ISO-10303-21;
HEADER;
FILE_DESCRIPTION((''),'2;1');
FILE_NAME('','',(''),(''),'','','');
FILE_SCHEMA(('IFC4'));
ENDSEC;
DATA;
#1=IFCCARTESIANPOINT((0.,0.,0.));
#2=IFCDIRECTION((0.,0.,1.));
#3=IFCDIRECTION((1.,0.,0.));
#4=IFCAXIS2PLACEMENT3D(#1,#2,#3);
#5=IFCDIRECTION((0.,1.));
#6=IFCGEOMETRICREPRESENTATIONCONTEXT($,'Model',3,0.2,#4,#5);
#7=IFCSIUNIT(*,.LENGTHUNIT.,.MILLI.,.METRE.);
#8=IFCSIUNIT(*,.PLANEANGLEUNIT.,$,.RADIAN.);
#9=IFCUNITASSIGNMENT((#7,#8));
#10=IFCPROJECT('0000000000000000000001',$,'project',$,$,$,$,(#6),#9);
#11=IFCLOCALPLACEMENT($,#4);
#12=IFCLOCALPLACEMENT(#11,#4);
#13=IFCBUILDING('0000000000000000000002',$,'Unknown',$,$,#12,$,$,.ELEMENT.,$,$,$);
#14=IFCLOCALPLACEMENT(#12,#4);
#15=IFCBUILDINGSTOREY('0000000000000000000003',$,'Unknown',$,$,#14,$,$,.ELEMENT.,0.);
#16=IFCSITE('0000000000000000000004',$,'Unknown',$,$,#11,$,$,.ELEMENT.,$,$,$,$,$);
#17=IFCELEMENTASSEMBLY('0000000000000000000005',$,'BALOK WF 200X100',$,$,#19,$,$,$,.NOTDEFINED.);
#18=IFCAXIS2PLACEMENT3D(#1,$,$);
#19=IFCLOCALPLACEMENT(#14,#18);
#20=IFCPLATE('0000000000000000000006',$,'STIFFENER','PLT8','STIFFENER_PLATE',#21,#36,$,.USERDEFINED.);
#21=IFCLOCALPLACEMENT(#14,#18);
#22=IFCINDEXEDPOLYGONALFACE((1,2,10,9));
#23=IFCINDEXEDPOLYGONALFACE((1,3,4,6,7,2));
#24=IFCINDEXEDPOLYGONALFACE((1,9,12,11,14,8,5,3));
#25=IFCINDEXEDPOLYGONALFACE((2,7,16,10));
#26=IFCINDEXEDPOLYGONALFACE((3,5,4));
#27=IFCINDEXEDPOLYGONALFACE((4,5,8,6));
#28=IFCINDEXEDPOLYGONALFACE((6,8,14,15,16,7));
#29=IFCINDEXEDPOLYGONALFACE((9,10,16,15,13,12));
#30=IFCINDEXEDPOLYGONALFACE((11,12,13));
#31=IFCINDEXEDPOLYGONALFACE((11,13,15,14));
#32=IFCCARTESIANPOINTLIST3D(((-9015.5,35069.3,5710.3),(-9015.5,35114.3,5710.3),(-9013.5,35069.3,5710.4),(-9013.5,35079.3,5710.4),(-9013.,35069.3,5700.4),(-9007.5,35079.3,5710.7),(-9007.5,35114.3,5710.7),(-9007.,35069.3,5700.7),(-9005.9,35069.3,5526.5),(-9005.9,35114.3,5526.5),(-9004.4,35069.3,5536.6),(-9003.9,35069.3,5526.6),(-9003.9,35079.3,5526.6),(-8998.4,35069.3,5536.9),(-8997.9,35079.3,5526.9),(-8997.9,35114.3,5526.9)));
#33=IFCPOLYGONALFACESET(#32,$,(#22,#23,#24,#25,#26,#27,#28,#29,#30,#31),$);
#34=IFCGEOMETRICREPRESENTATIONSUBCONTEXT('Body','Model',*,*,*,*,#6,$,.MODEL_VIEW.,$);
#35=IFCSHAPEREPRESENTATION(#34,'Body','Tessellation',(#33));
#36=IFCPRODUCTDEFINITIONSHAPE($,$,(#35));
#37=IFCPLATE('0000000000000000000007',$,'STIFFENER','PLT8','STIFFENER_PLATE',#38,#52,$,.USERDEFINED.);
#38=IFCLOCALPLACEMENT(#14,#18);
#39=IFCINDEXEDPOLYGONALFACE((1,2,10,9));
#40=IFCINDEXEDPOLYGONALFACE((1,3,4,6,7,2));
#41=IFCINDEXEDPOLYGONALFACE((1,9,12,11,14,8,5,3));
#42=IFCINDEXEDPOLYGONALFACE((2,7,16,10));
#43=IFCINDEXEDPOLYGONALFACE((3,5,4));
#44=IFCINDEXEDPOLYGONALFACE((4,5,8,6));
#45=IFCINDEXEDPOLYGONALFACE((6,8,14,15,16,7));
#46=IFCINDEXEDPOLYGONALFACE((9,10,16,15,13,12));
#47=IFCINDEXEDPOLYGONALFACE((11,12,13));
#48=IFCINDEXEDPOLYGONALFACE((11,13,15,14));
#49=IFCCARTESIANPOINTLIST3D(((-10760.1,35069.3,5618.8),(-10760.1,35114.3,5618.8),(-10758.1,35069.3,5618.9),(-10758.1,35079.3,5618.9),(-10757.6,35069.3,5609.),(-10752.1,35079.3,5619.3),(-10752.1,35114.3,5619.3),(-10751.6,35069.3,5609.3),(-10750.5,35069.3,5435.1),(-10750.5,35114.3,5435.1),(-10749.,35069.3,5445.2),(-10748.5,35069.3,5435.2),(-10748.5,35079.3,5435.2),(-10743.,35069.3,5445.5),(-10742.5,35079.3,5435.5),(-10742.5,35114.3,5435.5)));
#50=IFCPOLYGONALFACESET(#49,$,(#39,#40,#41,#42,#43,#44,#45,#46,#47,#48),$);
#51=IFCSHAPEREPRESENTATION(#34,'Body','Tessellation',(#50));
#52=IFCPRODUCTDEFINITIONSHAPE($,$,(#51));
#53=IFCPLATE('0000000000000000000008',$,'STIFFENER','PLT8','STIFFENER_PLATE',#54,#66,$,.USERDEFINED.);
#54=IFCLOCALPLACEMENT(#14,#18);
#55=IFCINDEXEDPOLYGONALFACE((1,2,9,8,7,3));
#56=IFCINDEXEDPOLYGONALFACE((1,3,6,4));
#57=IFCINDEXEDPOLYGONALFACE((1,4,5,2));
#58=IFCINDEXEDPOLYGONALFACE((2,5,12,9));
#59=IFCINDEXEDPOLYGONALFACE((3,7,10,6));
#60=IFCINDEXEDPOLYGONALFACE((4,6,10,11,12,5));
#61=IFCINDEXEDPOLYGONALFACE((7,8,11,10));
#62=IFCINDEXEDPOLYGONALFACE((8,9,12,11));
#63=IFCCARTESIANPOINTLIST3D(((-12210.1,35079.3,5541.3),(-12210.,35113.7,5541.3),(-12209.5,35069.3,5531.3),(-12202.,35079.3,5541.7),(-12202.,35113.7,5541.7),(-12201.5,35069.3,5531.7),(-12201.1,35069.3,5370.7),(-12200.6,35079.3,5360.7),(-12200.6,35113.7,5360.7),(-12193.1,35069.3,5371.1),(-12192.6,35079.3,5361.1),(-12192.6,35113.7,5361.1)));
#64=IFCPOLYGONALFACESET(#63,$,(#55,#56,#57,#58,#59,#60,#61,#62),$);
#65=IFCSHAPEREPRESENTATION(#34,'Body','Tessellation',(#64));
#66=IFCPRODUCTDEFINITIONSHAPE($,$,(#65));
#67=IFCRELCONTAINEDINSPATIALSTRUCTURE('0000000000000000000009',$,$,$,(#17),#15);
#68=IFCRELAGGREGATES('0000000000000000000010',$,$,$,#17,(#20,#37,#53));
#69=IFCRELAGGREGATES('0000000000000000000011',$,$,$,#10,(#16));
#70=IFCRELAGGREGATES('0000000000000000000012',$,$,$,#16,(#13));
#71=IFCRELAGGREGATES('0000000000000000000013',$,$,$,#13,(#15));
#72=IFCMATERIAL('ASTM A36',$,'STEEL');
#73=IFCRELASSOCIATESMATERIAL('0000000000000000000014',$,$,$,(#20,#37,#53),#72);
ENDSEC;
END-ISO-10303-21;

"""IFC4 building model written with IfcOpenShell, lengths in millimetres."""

from ifc_helpers import new_model, si_unit, direction, frame, origin_with_axes, place, context, subcontext, project, spatial, line, indexed_curve, outline, extrude, material, element, aggregate, save


model = new_model("IFC4")

# Units and contexts
model_context = context("Model", 3, precision=0.2, world=origin_with_axes(), true_north=direction((0.0, 1.0)))
body_context = subcontext(model_context, "Body", "Model", "MODEL_VIEW")
ifc_project = project(units=[si_unit("LENGTHUNIT", "METRE", prefix="MILLI"), si_unit("PLANEANGLEUNIT", "RADIAN")], contexts=[model_context])

# Site, building, storey
site_placement = place(None, origin_with_axes())
site = spatial("IfcSite", under=ifc_project, at=site_placement, Name="Unknown", CompositionType="ELEMENT")
building_placement = place(site_placement, origin_with_axes())
building = spatial("IfcBuilding", under=site, at=building_placement, Name="Unknown", CompositionType="ELEMENT")
storey_placement = place(building_placement, origin_with_axes())
storey = spatial("IfcBuildingStorey", under=building, at=storey_placement, Name="Unknown", CompositionType="ELEMENT", Elevation=0.0)

# Element assembly, plates, voiding features
assembly_1_placement = place(storey_placement, frame((-12592.0, 35066.5, 5430.7), z_axis=(0.0, -1.0, 0.0), x_axis=(0.99863, 0.0, 0.052336)))
assembly_1 = element("IfcElementAssembly", 1, at=assembly_1_placement, inside=storey, Name="BALOK WF 200X100", PredefinedType="NOTDEFINED")
ifc_material_1 = material(Name="ASTM A36", Category="STEEL")
plate_1_placement = place(assembly_1_placement, frame((3590.2, 92.0, -2.8), z_axis=(-1.0, 0.0, 0.0), x_axis=(0.0, 0.0, -1.0)))
plate_1 = element("IfcPlate", 2, at=plate_1_placement, material=ifc_material_1, Name="STIFFENER", Description="PLT8", ObjectType="STIFFENER_PLATE", PredefinedType="USERDEFINED", context=body_context, shape_type="SolidModel", body=[
    extrude(outline(indexed_curve([(0.0, 0.0), (45.0, 0.0), (45.0, 184.0), (0.0, 184.0)], segments=[line(1, 2, 3, 4, 1)])), frame((0.0, 0.0, 4.0), z_axis=(0.0, 0.0, 1.0), x_axis=(1.0, 0.0, 0.0)), (0.0, 0.0, -1.0), 8.0),
])
voiding_feature_1_placement = place(plate_1_placement, frame((0.0, 174.0, -1.0), z_axis=(0.0, 0.0, 1.0), x_axis=(0.707107, 0.707107, 0.0)))
element("IfcVoidingFeature", 3, at=voiding_feature_1_placement, cuts=plate_1, Name="SLAB", PredefinedType="HOLE", context=body_context, shape_type="SolidModel", body=[
    extrude(outline(indexed_curve([(0.0, 0.0), (14.1, 0.0), (7.1, 7.1)], segments=[line(1, 2, 3, 1)])), frame((0.0, 0.0, 3.0), z_axis=(0.0, 0.0, 1.0), x_axis=(1.0, 0.0, 0.0)), (0.0, 0.0, -1.0), 6.0),
])
voiding_feature_2_placement = place(plate_1_placement, frame((10.0, 0.0, -1.0), z_axis=(0.0, 0.0, 1.0), x_axis=(-0.707107, 0.707107, 0.0)))
element("IfcVoidingFeature", 4, at=voiding_feature_2_placement, cuts=plate_1, Name="SLAB", PredefinedType="HOLE", context=body_context, shape_type="SolidModel", body=[
    extrude(outline(indexed_curve([(0.0, 0.0), (14.1, 0.0), (7.1, 7.1)], segments=[line(1, 2, 3, 1)])), frame((0.0, 0.0, 3.0), z_axis=(0.0, 0.0, 1.0), x_axis=(1.0, 0.0, 0.0)), (0.0, 0.0, -1.0), 6.0),
])
plate_2_placement = place(assembly_1_placement, frame((1843.2, 92.0, -2.8), z_axis=(-1.0, 0.0, 0.0), x_axis=(0.0, 0.0, -1.0)))
plate_2 = element("IfcPlate", 5, at=plate_2_placement, material=ifc_material_1, Name="STIFFENER", Description="PLT8", ObjectType="STIFFENER_PLATE", PredefinedType="USERDEFINED", context=body_context, shape_type="SolidModel", body=[
    extrude(outline(indexed_curve([(0.0, 0.0), (45.0, 0.0), (45.0, 184.0), (0.0, 184.0)], segments=[line(1, 2, 3, 4, 1)])), frame((0.0, 0.0, 4.0), z_axis=(0.0, 0.0, 1.0), x_axis=(1.0, 0.0, 0.0)), (0.0, 0.0, -1.0), 8.0),
])
voiding_feature_3_placement = place(plate_2_placement, frame((0.0, 174.0, -1.0), z_axis=(0.0, 0.0, 1.0), x_axis=(0.707107, 0.707107, 0.0)))
element("IfcVoidingFeature", 6, at=voiding_feature_3_placement, cuts=plate_2, Name="SLAB", PredefinedType="HOLE", context=body_context, shape_type="SolidModel", body=[
    extrude(outline(indexed_curve([(0.0, 0.0), (14.1, 0.0), (7.1, 7.1)], segments=[line(1, 2, 3, 1)])), frame((0.0, 0.0, 3.0), z_axis=(0.0, 0.0, 1.0), x_axis=(1.0, 0.0, 0.0)), (0.0, 0.0, -1.0), 6.0),
])
voiding_feature_4_placement = place(plate_2_placement, frame((10.0, 0.0, -1.0), z_axis=(0.0, 0.0, 1.0), x_axis=(-0.707107, 0.707107, 0.0)))
element("IfcVoidingFeature", 7, at=voiding_feature_4_placement, cuts=plate_2, Name="SLAB", PredefinedType="HOLE", context=body_context, shape_type="SolidModel", body=[
    extrude(outline(indexed_curve([(0.0, 0.0), (14.1, 0.0), (7.1, 7.1)], segments=[line(1, 2, 3, 1)])), frame((0.0, 0.0, 3.0), z_axis=(0.0, 0.0, 1.0), x_axis=(1.0, 0.0, 0.0)), (0.0, 0.0, -1.0), 6.0),
])
plate_3_placement = place(assembly_1_placement, frame((391.2, -90.4, -2.8), z_axis=(1.0, 0.0, 0.0), x_axis=(0.0, 0.0, -1.0)))
plate_3 = element("IfcPlate", 8, at=plate_3_placement, material=ifc_material_1, Name="STIFFENER", Description="PLT8", ObjectType="STIFFENER_PLATE", PredefinedType="USERDEFINED", context=body_context, shape_type="SolidModel", body=[
    extrude(outline(indexed_curve([(0.0, 0.0), (44.5, 0.0), (44.5, 180.8), (0.0, 180.8)], segments=[line(1, 2, 3, 4, 1)])), frame((0.0, 0.0, 4.0), z_axis=(0.0, 0.0, 1.0), x_axis=(1.0, 0.0, 0.0)), (0.0, 0.0, -1.0), 8.0),
])
voiding_feature_5_placement = place(plate_3_placement, frame((0.0, 170.8, 0.0), z_axis=(0.0, 0.0, 1.0), x_axis=(0.707107, 0.707107, 0.0)))
element("IfcVoidingFeature", 9, at=voiding_feature_5_placement, cuts=plate_3, Name="SLAB", PredefinedType="HOLE", context=body_context, shape_type="SolidModel", body=[
    extrude(outline(indexed_curve([(0.0, 0.0), (14.1, 0.0), (7.1, 7.1)], segments=[line(1, 2, 3, 1)])), frame((0.0, 0.0, 4.0), z_axis=(0.0, 0.0, 1.0), x_axis=(1.0, 0.0, 0.0)), (0.0, 0.0, -1.0), 8.0),
])
voiding_feature_6_placement = place(plate_3_placement, frame((10.0, 0.0, 0.0), z_axis=(0.0, 0.0, 1.0), x_axis=(-0.707107, 0.707107, 0.0)))
element("IfcVoidingFeature", 10, at=voiding_feature_6_placement, cuts=plate_3, Name="SLAB", PredefinedType="HOLE", context=body_context, shape_type="SolidModel", body=[
    extrude(outline(indexed_curve([(0.0, 0.0), (14.1, 0.0), (7.1, 7.1)], segments=[line(1, 2, 3, 1)])), frame((0.0, 0.0, 4.0), z_axis=(0.0, 0.0, 1.0), x_axis=(1.0, 0.0, 0.0)), (0.0, 0.0, -1.0), 8.0),
])
aggregate(assembly_1, [plate_1, plate_2, plate_3])

save(model, "model.ifc")
